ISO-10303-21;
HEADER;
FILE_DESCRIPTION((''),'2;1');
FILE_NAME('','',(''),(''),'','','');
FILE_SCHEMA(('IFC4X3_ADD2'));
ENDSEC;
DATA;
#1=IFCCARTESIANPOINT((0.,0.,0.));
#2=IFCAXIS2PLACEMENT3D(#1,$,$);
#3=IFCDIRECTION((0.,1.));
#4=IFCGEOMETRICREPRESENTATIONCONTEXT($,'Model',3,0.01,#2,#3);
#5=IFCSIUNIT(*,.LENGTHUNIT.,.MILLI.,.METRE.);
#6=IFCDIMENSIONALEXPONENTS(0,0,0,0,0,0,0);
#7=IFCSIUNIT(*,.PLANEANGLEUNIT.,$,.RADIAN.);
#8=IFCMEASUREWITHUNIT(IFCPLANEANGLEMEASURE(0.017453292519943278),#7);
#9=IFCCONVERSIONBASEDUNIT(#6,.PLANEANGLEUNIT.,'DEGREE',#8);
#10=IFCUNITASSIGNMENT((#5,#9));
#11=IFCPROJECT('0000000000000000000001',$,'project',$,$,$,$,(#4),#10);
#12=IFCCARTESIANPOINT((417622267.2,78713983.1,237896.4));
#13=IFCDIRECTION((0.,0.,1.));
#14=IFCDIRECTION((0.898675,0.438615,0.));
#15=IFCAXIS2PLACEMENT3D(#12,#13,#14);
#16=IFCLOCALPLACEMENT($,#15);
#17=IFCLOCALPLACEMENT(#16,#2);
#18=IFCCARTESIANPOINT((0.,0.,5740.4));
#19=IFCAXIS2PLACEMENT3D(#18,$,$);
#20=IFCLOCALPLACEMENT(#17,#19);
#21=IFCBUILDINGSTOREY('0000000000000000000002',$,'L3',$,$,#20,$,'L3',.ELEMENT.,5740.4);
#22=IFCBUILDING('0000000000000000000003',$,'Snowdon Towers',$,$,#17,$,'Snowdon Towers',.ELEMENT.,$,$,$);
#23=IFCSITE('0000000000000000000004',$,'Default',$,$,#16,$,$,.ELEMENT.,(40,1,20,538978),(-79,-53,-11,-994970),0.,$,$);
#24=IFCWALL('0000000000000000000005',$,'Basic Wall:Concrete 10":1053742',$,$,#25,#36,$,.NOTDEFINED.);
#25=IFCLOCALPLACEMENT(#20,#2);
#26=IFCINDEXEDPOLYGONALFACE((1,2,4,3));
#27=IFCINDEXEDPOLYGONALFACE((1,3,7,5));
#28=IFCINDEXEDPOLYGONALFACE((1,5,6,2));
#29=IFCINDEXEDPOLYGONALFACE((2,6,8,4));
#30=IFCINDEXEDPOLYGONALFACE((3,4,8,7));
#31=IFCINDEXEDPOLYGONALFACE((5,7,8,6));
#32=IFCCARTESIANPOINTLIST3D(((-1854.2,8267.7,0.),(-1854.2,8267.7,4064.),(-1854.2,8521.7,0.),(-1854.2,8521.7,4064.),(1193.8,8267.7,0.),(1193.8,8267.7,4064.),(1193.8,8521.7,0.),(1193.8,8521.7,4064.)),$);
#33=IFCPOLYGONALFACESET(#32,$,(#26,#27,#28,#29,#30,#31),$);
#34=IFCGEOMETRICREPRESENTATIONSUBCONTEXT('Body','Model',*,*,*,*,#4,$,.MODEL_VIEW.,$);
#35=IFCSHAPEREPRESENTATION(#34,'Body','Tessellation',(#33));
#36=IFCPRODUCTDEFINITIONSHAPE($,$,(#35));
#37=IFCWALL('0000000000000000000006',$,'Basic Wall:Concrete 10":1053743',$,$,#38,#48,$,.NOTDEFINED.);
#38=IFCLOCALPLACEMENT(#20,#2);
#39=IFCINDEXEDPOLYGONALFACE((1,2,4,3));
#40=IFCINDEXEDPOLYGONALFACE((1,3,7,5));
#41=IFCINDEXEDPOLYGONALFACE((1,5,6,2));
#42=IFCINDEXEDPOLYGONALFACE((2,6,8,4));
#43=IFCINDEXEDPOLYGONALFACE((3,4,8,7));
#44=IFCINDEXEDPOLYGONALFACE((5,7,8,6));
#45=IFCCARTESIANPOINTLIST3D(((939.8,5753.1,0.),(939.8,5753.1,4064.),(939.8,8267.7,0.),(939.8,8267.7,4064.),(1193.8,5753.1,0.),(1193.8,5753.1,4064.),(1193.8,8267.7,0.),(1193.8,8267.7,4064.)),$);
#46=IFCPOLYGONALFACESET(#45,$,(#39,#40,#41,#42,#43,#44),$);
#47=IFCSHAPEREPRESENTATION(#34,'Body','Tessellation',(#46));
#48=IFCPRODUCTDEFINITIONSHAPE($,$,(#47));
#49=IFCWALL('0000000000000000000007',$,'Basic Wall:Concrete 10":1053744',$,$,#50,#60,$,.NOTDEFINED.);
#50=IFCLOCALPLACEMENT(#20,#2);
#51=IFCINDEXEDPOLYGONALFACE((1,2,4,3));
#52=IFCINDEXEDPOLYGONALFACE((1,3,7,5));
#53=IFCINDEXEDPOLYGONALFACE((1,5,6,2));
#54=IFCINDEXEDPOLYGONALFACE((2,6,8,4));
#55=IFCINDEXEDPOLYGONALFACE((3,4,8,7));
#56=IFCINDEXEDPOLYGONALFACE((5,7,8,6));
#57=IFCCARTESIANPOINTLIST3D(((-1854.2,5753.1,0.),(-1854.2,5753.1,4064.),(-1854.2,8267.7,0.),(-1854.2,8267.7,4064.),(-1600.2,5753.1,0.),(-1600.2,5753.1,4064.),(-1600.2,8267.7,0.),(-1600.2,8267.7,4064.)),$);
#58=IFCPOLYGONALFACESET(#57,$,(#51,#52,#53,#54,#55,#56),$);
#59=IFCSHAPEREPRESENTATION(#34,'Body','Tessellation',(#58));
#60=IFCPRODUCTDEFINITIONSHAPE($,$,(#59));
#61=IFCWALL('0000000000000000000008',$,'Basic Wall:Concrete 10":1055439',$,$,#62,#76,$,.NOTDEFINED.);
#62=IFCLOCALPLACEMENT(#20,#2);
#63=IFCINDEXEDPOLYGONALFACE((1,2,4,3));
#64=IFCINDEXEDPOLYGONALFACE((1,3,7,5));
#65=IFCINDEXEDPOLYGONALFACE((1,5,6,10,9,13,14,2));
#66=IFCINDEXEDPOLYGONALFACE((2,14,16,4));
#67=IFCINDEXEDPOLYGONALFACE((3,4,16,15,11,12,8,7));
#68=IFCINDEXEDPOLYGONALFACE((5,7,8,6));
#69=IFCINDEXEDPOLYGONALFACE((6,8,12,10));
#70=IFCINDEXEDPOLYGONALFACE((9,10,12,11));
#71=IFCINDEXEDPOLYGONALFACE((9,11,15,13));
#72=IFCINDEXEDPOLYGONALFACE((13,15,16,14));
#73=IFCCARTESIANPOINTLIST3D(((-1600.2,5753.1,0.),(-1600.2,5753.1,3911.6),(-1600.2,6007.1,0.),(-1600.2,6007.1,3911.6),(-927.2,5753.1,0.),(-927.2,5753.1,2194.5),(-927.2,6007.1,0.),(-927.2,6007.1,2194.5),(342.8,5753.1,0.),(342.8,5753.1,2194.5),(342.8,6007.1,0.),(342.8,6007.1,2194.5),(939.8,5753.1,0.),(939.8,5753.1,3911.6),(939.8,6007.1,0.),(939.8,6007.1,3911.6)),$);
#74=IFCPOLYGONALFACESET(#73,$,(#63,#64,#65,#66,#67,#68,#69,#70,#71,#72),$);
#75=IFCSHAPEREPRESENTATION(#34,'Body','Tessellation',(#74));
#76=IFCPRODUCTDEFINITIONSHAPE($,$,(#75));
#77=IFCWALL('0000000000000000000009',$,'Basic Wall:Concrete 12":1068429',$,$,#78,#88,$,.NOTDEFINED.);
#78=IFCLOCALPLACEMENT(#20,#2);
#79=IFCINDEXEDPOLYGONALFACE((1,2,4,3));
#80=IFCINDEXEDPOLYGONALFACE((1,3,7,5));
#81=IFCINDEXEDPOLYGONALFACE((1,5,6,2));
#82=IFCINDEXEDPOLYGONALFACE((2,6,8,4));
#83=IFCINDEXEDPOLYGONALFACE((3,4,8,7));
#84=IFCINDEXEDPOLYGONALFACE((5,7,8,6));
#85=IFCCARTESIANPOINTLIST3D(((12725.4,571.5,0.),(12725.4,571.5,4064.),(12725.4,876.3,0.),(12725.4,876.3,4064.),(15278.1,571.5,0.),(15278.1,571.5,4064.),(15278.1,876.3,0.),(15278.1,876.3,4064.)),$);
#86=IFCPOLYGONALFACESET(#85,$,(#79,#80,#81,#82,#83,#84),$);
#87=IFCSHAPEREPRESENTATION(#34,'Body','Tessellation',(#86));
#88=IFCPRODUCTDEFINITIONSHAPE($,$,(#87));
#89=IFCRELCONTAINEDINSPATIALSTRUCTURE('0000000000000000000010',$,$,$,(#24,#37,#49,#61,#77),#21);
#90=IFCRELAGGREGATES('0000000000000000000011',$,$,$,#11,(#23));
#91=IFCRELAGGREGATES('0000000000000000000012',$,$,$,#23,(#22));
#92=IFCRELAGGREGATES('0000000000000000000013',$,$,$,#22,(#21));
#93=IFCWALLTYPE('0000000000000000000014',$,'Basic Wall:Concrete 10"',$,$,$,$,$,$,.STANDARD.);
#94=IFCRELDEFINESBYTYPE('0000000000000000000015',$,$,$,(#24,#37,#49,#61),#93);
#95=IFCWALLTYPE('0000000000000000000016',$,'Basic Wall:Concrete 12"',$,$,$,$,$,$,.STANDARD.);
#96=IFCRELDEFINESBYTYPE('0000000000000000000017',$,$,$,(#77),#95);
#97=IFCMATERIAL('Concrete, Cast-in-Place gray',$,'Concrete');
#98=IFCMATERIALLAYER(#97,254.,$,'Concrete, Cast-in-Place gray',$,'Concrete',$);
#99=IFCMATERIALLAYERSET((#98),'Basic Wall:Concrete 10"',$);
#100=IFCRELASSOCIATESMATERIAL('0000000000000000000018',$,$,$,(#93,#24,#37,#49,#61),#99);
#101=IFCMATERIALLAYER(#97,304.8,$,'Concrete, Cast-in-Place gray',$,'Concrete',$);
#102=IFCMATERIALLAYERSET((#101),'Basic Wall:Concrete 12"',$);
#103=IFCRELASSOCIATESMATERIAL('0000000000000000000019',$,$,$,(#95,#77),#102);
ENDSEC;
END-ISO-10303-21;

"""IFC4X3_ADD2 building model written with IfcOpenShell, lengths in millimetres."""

from ifc_helpers import new_model, entity, si_unit, converted_unit, direction, frame, frame_2d, origin, place, context, subcontext, project, spatial, rectangle, extrude, material, layer, layer_set, type_object, element, save


model = new_model("IFC4X3_ADD2")

# Units and contexts
model_context = context("Model", 3, precision=0.01, world=origin(), true_north=direction((0.0, 1.0)))
body_context = subcontext(model_context, "Body", "Model", "MODEL_VIEW")
ifc_project = project(units=[si_unit("LENGTHUNIT", "METRE", prefix="MILLI"), converted_unit("PLANEANGLEUNIT", "DEGREE", entity("IfcPlaneAngleMeasure", 0.017453292519943278), si_unit("PLANEANGLEUNIT", "RADIAN"), dimensions=[0, 0, 0, 0, 0, 0, 0])], contexts=[model_context])

# Site, building, storey
site_placement = place(None, frame((417622267.2, 78713983.1, 237896.4), z_axis=(0.0, 0.0, 1.0), x_axis=(0.898675, 0.438615, 0.0)))
site = spatial("IfcSite", under=ifc_project, at=site_placement, Name="Default", CompositionType="ELEMENT", RefLatitude=(40, 1, 20, 538978), RefLongitude=(-79, -53, -11, -994970), RefElevation=0.0)
building_placement = place(site_placement, origin())
building = spatial("IfcBuilding", under=site, at=building_placement, Name="Snowdon Towers", LongName="Snowdon Towers", CompositionType="ELEMENT")
storey_placement = place(building_placement, frame((0.0, 0.0, 5740.4)))
storey = spatial("IfcBuildingStorey", under=building, at=storey_placement, Name="L3", LongName="L3", CompositionType="ELEMENT", Elevation=5740.4)

# Walls
ifc_material_1 = material(Name="Concrete, Cast-in-Place gray", Category="Concrete")
ifc_layer_1 = layer(ifc_material_1, 254.0, Name="Concrete, Cast-in-Place gray", Category="Concrete")
ifc_layer_set_1 = layer_set([ifc_layer_1], Name="Basic Wall:Concrete 10\"")
wall_type_1 = type_object("IfcWallType", Name="Basic Wall:Concrete 10\"", PredefinedType="STANDARD", material=ifc_layer_set_1)
wall_1_placement = place(storey_placement, frame((-1854.2, 8394.7, 0.0)))
element("IfcWall", 1, at=wall_1_placement, inside=storey, type_object=wall_type_1, material=ifc_layer_set_1, Name="Basic Wall:Concrete 10\":1053742", PredefinedType="NOTDEFINED", context=body_context, shape_type="SweptSolid", body=[
    extrude(rectangle(XDim=3048.0, YDim=254.0, at=frame_2d((1524.0, 0.0), x_axis=(-1.0, 0.0))), origin(), (0.0, 0.0, 1.0), 4064.0),
])
wall_2_placement = place(storey_placement, frame((1066.8, 8267.7, 0.0), z_axis=(0.0, 0.0, 1.0), x_axis=(0.0, -1.0, 0.0)))
element("IfcWall", 2, at=wall_2_placement, inside=storey, type_object=wall_type_1, material=ifc_layer_set_1, Name="Basic Wall:Concrete 10\":1053743", PredefinedType="NOTDEFINED", context=body_context, shape_type="SweptSolid", body=[
    extrude(rectangle(XDim=2514.6, YDim=254.0, at=frame_2d((1257.3, 0.0), x_axis=(-1.0, 0.0))), origin(), (0.0, 0.0, 1.0), 4064.0),
])
wall_3_placement = place(storey_placement, frame((-1727.2, 5753.1, 0.0), z_axis=(0.0, 0.0, 1.0), x_axis=(0.0, 1.0, 0.0)))
element("IfcWall", 3, at=wall_3_placement, inside=storey, type_object=wall_type_1, material=ifc_layer_set_1, Name="Basic Wall:Concrete 10\":1053744", PredefinedType="NOTDEFINED", context=body_context, shape_type="SweptSolid", body=[
    extrude(rectangle(XDim=2514.6, YDim=254.0, at=frame_2d((1257.3, 0.0), x_axis=(-1.0, 0.0))), origin(), (0.0, 0.0, 1.0), 4064.0),
])

# Wall, opening
wall_4_placement = place(storey_placement, frame((939.8, 5880.1, 0.0), z_axis=(0.0, 0.0, 1.0), x_axis=(-1.0, 0.0, 0.0)))
wall_4 = element("IfcWall", 4, at=wall_4_placement, inside=storey, type_object=wall_type_1, material=ifc_layer_set_1, Name="Basic Wall:Concrete 10\":1055439", PredefinedType="NOTDEFINED", context=body_context, shape_type="SweptSolid", body=[
    extrude(rectangle(XDim=2540.0, YDim=254.0, at=frame_2d((1270.0, 0.0), x_axis=(-1.0, 0.0))), origin(), (0.0, 0.0, 1.0), 3911.6),
])
opening_placement = place(wall_4_placement, origin())
element("IfcOpeningElement", 5, at=opening_placement, cuts=wall_4, PredefinedType="OPENING", context=body_context, shape_type="SweptSolid", body=[
    extrude(rectangle(XDim=2194.5, YDim=1270.0, at=frame_2d((0.0, 0.0), x_axis=(0.0, -1.0))), frame((1232.0, 127.0, 1097.2), z_axis=(0.0, 1.0, 0.0), x_axis=(1.0, 0.0, 0.0)), (0.0, 0.0, -1.0), 254.0),
])

# Wall
ifc_layer_2 = layer(ifc_material_1, 304.8, Name="Concrete, Cast-in-Place gray", Category="Concrete")
ifc_layer_set_2 = layer_set([ifc_layer_2], Name="Basic Wall:Concrete 12\"")
wall_type_2 = type_object("IfcWallType", Name="Basic Wall:Concrete 12\"", PredefinedType="STANDARD", material=ifc_layer_set_2)
wall_5_placement = place(storey_placement, frame((15278.1, 723.9, 0.0), z_axis=(0.0, 0.0, 1.0), x_axis=(-1.0, 0.0, 0.0)))
element("IfcWall", 6, at=wall_5_placement, inside=storey, type_object=wall_type_2, material=ifc_layer_set_2, Name="Basic Wall:Concrete 12\":1068429", PredefinedType="NOTDEFINED", context=body_context, shape_type="SweptSolid", body=[
    extrude(rectangle(XDim=2552.7, YDim=304.8, at=frame_2d((1276.3, 0.0), x_axis=(-1.0, 0.0))), origin(), (0.0, 0.0, 1.0), 4064.0),
])

save(model, "model.ifc")
